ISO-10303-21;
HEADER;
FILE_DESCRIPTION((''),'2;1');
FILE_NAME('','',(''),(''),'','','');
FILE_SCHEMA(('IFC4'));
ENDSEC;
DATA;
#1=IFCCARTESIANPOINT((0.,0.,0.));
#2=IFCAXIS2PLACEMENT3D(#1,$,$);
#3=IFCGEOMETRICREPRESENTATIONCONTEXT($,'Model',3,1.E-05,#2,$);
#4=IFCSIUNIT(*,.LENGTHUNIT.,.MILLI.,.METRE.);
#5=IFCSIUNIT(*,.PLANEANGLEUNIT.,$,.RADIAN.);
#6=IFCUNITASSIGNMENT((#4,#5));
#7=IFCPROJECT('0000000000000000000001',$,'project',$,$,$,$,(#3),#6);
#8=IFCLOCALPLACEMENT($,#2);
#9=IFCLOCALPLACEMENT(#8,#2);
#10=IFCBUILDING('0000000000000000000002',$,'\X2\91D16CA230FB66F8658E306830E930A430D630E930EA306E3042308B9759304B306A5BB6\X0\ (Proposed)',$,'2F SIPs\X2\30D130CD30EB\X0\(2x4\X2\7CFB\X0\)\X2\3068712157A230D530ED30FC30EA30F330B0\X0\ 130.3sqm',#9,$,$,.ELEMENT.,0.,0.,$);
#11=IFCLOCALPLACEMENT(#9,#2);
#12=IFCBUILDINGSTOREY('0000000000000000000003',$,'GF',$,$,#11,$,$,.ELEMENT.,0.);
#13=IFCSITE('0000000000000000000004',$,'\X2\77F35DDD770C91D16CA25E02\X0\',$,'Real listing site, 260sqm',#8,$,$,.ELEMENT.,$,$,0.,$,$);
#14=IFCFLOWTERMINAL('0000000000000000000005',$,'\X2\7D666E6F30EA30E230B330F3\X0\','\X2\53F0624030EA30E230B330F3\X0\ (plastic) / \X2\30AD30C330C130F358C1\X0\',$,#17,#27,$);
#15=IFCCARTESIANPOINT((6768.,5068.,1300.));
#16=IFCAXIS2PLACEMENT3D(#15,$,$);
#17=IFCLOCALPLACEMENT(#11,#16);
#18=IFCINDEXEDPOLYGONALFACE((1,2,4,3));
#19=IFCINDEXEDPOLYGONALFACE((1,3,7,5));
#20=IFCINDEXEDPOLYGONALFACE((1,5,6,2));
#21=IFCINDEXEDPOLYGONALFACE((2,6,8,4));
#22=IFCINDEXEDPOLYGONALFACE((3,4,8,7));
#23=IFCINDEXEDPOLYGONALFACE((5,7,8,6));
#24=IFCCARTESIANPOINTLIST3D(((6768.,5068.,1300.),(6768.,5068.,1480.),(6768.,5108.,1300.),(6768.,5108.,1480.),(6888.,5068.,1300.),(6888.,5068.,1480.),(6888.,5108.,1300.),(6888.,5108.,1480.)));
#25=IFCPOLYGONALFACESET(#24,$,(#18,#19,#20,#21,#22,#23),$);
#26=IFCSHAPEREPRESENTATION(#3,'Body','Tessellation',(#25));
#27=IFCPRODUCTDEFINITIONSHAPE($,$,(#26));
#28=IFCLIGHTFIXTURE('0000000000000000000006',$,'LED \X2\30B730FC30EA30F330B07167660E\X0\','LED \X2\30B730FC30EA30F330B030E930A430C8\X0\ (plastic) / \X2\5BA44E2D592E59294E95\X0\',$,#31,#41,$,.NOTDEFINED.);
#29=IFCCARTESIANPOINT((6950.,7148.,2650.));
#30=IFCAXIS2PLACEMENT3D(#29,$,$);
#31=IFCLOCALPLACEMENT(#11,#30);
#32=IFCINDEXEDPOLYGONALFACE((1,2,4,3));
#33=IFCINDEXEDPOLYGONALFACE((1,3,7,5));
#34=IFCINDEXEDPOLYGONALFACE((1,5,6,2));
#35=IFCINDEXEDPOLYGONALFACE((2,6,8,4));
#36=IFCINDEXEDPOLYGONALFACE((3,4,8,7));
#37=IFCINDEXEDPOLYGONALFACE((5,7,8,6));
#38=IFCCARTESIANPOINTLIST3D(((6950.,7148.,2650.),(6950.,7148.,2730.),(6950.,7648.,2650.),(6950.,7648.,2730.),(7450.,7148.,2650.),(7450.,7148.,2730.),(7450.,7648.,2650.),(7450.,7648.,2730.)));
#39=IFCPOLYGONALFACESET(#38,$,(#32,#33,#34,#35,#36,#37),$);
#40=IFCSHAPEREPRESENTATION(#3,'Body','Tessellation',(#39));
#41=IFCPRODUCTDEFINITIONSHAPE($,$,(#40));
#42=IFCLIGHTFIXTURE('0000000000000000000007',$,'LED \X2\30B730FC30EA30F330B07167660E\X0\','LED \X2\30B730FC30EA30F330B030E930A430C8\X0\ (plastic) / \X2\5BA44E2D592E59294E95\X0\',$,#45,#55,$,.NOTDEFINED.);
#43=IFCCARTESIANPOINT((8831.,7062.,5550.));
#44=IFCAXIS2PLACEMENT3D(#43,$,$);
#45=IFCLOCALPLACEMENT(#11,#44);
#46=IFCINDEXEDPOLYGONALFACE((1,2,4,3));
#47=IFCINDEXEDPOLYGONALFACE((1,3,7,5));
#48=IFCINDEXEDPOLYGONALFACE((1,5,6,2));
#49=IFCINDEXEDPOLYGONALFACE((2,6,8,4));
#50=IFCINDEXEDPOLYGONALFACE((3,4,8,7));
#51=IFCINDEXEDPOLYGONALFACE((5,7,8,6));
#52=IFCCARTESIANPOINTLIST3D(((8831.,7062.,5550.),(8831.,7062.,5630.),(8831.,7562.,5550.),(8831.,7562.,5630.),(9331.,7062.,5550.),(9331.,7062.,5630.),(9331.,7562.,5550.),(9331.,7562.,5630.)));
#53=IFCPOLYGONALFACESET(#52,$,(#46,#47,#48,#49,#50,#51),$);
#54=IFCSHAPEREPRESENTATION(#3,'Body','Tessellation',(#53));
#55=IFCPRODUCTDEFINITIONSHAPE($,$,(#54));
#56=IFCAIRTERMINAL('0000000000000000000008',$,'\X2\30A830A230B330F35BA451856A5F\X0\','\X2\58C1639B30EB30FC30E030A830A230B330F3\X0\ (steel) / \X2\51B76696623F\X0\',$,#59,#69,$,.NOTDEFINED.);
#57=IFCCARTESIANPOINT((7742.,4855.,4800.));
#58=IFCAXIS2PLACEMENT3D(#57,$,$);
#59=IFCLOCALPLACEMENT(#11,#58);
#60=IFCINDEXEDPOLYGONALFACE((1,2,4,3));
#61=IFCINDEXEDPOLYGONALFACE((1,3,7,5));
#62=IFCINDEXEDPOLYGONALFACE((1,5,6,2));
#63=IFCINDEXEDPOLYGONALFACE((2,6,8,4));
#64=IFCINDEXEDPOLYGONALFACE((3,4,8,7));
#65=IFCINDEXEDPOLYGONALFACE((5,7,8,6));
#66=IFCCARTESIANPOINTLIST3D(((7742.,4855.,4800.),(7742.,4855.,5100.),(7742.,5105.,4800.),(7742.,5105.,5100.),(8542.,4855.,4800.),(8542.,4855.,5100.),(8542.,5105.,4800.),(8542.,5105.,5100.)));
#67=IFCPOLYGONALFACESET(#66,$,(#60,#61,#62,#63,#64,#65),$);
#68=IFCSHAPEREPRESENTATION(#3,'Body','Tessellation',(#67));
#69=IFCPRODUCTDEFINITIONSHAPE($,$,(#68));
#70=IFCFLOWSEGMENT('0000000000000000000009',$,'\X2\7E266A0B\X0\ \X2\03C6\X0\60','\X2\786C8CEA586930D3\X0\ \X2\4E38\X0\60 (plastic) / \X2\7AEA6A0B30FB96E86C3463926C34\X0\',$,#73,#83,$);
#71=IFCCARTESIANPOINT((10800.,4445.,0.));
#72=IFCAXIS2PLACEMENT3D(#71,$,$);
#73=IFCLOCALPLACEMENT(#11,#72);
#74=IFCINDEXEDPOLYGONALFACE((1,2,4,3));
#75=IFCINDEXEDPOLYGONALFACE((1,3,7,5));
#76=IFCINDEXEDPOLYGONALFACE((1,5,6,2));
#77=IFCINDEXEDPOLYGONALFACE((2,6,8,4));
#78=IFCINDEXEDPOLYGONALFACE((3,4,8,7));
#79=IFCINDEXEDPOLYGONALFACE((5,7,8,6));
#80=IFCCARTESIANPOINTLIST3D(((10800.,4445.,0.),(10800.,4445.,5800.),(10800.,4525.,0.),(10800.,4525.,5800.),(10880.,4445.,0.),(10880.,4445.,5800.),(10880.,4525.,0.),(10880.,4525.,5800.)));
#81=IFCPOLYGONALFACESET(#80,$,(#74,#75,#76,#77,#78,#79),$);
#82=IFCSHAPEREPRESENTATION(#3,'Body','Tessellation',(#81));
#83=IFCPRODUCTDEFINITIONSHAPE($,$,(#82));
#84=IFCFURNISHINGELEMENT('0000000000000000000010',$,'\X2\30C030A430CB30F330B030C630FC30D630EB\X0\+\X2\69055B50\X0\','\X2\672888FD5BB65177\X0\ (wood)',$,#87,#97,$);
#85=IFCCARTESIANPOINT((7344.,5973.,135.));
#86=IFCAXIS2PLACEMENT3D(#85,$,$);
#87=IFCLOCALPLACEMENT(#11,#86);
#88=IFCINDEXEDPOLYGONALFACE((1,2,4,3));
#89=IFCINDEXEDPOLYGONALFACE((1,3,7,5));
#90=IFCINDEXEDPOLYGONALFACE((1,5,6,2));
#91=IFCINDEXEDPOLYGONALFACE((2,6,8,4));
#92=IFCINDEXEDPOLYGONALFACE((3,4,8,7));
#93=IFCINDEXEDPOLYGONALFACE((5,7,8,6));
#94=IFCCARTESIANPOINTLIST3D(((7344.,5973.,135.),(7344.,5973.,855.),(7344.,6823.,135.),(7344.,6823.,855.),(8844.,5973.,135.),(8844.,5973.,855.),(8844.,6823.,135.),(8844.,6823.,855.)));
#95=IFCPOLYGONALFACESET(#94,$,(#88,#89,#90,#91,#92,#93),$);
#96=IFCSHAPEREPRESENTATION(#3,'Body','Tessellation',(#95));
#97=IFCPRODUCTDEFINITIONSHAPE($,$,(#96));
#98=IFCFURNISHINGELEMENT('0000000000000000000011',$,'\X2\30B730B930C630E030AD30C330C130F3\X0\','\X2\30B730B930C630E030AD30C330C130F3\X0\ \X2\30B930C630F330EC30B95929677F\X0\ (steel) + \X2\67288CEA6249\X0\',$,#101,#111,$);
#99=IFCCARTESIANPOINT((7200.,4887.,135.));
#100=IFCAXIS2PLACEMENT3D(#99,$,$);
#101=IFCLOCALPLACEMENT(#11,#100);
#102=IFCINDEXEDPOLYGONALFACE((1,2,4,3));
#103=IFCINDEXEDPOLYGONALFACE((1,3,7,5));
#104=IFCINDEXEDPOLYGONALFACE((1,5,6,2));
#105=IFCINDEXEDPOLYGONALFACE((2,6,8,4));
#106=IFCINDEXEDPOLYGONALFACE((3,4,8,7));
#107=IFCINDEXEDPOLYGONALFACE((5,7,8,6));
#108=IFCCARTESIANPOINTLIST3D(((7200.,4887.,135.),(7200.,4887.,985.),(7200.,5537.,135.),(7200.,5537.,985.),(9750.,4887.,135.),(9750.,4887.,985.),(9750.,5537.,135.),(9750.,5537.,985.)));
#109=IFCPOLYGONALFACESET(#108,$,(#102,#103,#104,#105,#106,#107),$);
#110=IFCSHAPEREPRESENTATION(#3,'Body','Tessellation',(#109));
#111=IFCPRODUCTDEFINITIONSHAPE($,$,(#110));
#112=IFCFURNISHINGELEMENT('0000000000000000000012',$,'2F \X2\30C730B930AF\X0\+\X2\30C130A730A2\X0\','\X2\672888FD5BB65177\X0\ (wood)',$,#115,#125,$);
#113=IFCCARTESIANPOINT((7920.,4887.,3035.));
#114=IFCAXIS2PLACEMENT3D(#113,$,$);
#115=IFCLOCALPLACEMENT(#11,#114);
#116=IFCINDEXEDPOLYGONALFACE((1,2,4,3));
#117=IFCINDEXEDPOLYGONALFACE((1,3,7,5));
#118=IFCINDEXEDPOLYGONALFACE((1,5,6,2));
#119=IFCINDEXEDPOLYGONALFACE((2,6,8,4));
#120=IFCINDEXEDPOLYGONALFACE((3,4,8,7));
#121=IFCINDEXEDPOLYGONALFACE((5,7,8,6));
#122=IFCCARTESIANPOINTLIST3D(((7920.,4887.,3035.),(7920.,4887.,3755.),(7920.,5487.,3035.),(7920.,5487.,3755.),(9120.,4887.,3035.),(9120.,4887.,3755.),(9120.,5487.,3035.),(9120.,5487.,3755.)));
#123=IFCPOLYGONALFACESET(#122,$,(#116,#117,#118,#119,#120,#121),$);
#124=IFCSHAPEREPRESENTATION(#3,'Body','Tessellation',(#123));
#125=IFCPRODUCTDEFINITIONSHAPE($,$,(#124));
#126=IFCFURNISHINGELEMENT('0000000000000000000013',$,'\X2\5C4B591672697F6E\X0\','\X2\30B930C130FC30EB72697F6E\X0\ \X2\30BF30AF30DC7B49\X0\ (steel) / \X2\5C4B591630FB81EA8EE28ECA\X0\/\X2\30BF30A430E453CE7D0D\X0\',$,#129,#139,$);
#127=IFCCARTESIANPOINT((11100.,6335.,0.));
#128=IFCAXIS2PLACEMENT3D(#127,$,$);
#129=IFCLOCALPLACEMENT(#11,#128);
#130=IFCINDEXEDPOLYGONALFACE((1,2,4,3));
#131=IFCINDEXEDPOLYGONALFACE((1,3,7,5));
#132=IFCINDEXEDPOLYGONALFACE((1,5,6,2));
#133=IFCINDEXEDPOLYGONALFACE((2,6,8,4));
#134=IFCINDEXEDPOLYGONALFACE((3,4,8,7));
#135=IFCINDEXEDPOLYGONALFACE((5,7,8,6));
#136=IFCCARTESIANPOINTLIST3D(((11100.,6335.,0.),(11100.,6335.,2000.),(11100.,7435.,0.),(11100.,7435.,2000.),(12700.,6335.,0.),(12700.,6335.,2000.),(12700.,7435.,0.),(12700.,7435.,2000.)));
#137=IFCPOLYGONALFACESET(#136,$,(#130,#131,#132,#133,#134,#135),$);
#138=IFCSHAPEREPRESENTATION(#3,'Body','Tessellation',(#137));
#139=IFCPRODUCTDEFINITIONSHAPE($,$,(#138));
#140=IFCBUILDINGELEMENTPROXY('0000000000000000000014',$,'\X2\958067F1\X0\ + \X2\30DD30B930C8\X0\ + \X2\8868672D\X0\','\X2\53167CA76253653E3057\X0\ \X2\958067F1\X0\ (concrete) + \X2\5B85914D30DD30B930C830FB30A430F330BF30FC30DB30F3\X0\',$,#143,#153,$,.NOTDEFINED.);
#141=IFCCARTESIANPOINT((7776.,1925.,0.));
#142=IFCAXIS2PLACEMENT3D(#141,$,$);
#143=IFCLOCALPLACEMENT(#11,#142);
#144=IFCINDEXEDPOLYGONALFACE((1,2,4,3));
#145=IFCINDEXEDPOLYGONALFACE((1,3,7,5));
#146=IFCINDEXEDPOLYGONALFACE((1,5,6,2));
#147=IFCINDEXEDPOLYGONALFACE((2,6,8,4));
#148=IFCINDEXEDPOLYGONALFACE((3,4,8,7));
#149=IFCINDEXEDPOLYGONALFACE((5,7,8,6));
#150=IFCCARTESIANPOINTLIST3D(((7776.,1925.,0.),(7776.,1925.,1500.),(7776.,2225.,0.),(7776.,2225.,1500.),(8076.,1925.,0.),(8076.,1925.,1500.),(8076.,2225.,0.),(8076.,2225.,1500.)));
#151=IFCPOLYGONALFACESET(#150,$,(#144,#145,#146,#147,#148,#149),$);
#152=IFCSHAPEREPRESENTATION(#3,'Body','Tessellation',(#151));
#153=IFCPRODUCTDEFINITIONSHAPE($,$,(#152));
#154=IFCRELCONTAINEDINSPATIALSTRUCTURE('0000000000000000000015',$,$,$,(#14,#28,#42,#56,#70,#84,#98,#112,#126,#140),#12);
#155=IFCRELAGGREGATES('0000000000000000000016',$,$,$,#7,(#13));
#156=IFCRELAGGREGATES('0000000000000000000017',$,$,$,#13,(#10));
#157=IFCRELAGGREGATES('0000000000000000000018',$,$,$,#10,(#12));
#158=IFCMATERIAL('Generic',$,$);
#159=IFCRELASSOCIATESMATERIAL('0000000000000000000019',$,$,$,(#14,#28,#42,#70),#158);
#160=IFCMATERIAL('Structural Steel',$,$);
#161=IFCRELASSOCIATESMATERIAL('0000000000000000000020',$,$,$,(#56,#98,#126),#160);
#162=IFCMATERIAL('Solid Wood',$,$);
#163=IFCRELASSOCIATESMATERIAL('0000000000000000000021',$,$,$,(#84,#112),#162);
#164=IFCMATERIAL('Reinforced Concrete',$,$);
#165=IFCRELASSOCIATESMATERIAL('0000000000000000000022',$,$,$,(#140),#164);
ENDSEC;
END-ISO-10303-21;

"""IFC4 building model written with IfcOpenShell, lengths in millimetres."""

from ifc_helpers import new_model, si_unit, frame, frame_2d, origin, place, context, project, spatial, rectangle, extrude, material, element, save


model = new_model("IFC4")

# Units and contexts
model_context = context("Model", 3, precision=1e-05, world=origin())
ifc_project = project(units=[si_unit("LENGTHUNIT", "METRE", prefix="MILLI"), si_unit("PLANEANGLEUNIT", "RADIAN")], contexts=[model_context])

# Site, building, storey
site_placement = place(None, origin())
site = spatial("IfcSite", under=ifc_project, at=site_placement, Name="石川県金沢市", ObjectType="Real listing site, 260sqm", CompositionType="ELEMENT", RefElevation=0.0)
building_placement = place(site_placement, origin())
building = spatial("IfcBuilding", under=site, at=building_placement, Name="金沢・書斎とライブラリのある静かな家 (Proposed)", ObjectType="2F SIPsパネル(2x4系)と無垢フローリング 130.3sqm", CompositionType="ELEMENT", ElevationOfRefHeight=0.0, ElevationOfTerrain=0.0)
storey_placement = place(building_placement, origin())
storey = spatial("IfcBuildingStorey", under=building, at=storey_placement, Name="GF", CompositionType="ELEMENT", Elevation=0.0)

# Shared definitions
ifc_material_1 = material(Name="Solid Wood")

# Shared definitions
ifc_material_2 = material(Name="Reinforced Concrete")

# Shared definitions
ifc_material_3 = material(Name="Structural Steel")

# Flow terminal
ifc_material_4 = material(Name="Generic")
flow_terminal_1_placement = place(storey_placement, frame((6768.0, 5068.0, 1300.0)))
element("IfcFlowTerminal", 1, at=flow_terminal_1_placement, inside=storey, material=ifc_material_4, Name="給湯リモコン", Description="台所リモコン (plastic) / キッチン壁", context=model_context, shape_type="SweptSolid", body=[
    extrude(rectangle(XDim=120.0, YDim=40.0, at=frame_2d((60.0, 20.0))), frame((6768.0, 5068.0, 1300.0)), (0.0, 0.0, 1.0), 180.0),
])

# Light fixtures
light_fixture_1_placement = place(storey_placement, frame((6950.0, 7148.0, 2650.0)))
element("IfcLightFixture", 2, at=light_fixture_1_placement, inside=storey, material=ifc_material_4, Name="LED シーリング照明", Description="LED シーリングライト (plastic) / 室中央天井", PredefinedType="NOTDEFINED", context=model_context, shape_type="SweptSolid", body=[
    extrude(rectangle(XDim=500.0, YDim=500.0, at=frame_2d((250.0, 250.0))), frame((6950.0, 7148.0, 2650.0)), (0.0, 0.0, 1.0), 80.0),
])
light_fixture_2_placement = place(storey_placement, frame((8831.0, 7062.0, 5550.0)))
element("IfcLightFixture", 3, at=light_fixture_2_placement, inside=storey, material=ifc_material_4, Name="LED シーリング照明", Description="LED シーリングライト (plastic) / 室中央天井", PredefinedType="NOTDEFINED", context=model_context, shape_type="SweptSolid", body=[
    extrude(rectangle(XDim=500.0, YDim=500.0, at=frame_2d((250.0, 250.0))), frame((8831.0, 7062.0, 5550.0)), (0.0, 0.0, 1.0), 80.0),
])

# Air terminal
air_terminal_placement = place(storey_placement, frame((7742.0, 4855.0, 4800.0)))
element("IfcAirTerminal", 4, at=air_terminal_placement, inside=storey, material=ifc_material_3, Name="エアコン室内機", Description="壁掛ルームエアコン (steel) / 冷暖房", PredefinedType="NOTDEFINED", context=model_context, shape_type="SweptSolid", body=[
    extrude(rectangle(XDim=800.0, YDim=250.0, at=frame_2d((400.0, 125.0))), frame((7742.0, 4855.0, 4800.0)), (0.0, 0.0, 1.0), 300.0),
])

# Flow segment
flow_segment_placement = place(storey_placement, frame((10800.0, 4445.0, 0.0)))
element("IfcFlowSegment", 5, at=flow_segment_placement, inside=storey, material=ifc_material_4, Name="縦樋 φ60", Description="硬質塩ビ 丸60 (plastic) / 竪樋・雨水排水", context=model_context, shape_type="SweptSolid", body=[
    extrude(rectangle(XDim=80.0, YDim=80.0, at=frame_2d((40.0, 40.0))), frame((10800.0, 4445.0, 0.0)), (0.0, 0.0, 1.0), 5800.0),
])

# Furnishing elements
furnishing_1_placement = place(storey_placement, frame((7344.0, 5973.0, 135.0)))
element("IfcFurnishingElement", 6, at=furnishing_1_placement, inside=storey, material=ifc_material_1, Name="ダイニングテーブル+椅子", Description="木製家具 (wood)", context=model_context, shape_type="SweptSolid", body=[
    extrude(rectangle(XDim=1500.0, YDim=850.0, at=frame_2d((750.0, 425.0))), frame((7344.0, 5973.0, 135.0)), (0.0, 0.0, 1.0), 720.0),
])
furnishing_2_placement = place(storey_placement, frame((7200.0, 4887.0, 135.0)))
element("IfcFurnishingElement", 7, at=furnishing_2_placement, inside=storey, material=ifc_material_3, Name="システムキッチン", Description="システムキッチン ステンレス天板 (steel) + 木質扉", context=model_context, shape_type="SweptSolid", body=[
    extrude(rectangle(XDim=2550.0, YDim=650.0, at=frame_2d((1275.0, 325.0))), frame((7200.0, 4887.0, 135.0)), (0.0, 0.0, 1.0), 850.0),
])
furnishing_3_placement = place(storey_placement, frame((7920.0, 4887.0, 3035.0)))
element("IfcFurnishingElement", 8, at=furnishing_3_placement, inside=storey, material=ifc_material_1, Name="2F デスク+チェア", Description="木製家具 (wood)", context=model_context, shape_type="SweptSolid", body=[
    extrude(rectangle(XDim=1200.0, YDim=600.0, at=frame_2d((600.0, 300.0))), frame((7920.0, 4887.0, 3035.0)), (0.0, 0.0, 1.0), 720.0),
])
furnishing_4_placement = place(storey_placement, frame((11100.0, 6335.0, 0.0)))
element("IfcFurnishingElement", 9, at=furnishing_4_placement, inside=storey, material=ifc_material_3, Name="屋外物置", Description="スチール物置 タクボ等 (steel) / 屋外・自転車/タイヤ収納", context=model_context, shape_type="SweptSolid", body=[
    extrude(rectangle(XDim=1600.0, YDim=1100.0, at=frame_2d((800.0, 550.0))), frame((11100.0, 6335.0, 0.0)), (0.0, 0.0, 1.0), 2000.0),
])

# Building element proxy
proxy_placement = place(storey_placement, frame((7776.0, 1925.0, 0.0)))
element("IfcBuildingElementProxy", 10, at=proxy_placement, inside=storey, material=ifc_material_2, Name="門柱 + ポスト + 表札", Description="化粧打放し 門柱 (concrete) + 宅配ポスト・インターホン", PredefinedType="NOTDEFINED", context=model_context, shape_type="SweptSolid", body=[
    extrude(rectangle(XDim=300.0, YDim=300.0, at=frame_2d((150.0, 150.0))), frame((7776.0, 1925.0, 0.0)), (0.0, 0.0, 1.0), 1500.0),
])

save(model, "model.ifc")
